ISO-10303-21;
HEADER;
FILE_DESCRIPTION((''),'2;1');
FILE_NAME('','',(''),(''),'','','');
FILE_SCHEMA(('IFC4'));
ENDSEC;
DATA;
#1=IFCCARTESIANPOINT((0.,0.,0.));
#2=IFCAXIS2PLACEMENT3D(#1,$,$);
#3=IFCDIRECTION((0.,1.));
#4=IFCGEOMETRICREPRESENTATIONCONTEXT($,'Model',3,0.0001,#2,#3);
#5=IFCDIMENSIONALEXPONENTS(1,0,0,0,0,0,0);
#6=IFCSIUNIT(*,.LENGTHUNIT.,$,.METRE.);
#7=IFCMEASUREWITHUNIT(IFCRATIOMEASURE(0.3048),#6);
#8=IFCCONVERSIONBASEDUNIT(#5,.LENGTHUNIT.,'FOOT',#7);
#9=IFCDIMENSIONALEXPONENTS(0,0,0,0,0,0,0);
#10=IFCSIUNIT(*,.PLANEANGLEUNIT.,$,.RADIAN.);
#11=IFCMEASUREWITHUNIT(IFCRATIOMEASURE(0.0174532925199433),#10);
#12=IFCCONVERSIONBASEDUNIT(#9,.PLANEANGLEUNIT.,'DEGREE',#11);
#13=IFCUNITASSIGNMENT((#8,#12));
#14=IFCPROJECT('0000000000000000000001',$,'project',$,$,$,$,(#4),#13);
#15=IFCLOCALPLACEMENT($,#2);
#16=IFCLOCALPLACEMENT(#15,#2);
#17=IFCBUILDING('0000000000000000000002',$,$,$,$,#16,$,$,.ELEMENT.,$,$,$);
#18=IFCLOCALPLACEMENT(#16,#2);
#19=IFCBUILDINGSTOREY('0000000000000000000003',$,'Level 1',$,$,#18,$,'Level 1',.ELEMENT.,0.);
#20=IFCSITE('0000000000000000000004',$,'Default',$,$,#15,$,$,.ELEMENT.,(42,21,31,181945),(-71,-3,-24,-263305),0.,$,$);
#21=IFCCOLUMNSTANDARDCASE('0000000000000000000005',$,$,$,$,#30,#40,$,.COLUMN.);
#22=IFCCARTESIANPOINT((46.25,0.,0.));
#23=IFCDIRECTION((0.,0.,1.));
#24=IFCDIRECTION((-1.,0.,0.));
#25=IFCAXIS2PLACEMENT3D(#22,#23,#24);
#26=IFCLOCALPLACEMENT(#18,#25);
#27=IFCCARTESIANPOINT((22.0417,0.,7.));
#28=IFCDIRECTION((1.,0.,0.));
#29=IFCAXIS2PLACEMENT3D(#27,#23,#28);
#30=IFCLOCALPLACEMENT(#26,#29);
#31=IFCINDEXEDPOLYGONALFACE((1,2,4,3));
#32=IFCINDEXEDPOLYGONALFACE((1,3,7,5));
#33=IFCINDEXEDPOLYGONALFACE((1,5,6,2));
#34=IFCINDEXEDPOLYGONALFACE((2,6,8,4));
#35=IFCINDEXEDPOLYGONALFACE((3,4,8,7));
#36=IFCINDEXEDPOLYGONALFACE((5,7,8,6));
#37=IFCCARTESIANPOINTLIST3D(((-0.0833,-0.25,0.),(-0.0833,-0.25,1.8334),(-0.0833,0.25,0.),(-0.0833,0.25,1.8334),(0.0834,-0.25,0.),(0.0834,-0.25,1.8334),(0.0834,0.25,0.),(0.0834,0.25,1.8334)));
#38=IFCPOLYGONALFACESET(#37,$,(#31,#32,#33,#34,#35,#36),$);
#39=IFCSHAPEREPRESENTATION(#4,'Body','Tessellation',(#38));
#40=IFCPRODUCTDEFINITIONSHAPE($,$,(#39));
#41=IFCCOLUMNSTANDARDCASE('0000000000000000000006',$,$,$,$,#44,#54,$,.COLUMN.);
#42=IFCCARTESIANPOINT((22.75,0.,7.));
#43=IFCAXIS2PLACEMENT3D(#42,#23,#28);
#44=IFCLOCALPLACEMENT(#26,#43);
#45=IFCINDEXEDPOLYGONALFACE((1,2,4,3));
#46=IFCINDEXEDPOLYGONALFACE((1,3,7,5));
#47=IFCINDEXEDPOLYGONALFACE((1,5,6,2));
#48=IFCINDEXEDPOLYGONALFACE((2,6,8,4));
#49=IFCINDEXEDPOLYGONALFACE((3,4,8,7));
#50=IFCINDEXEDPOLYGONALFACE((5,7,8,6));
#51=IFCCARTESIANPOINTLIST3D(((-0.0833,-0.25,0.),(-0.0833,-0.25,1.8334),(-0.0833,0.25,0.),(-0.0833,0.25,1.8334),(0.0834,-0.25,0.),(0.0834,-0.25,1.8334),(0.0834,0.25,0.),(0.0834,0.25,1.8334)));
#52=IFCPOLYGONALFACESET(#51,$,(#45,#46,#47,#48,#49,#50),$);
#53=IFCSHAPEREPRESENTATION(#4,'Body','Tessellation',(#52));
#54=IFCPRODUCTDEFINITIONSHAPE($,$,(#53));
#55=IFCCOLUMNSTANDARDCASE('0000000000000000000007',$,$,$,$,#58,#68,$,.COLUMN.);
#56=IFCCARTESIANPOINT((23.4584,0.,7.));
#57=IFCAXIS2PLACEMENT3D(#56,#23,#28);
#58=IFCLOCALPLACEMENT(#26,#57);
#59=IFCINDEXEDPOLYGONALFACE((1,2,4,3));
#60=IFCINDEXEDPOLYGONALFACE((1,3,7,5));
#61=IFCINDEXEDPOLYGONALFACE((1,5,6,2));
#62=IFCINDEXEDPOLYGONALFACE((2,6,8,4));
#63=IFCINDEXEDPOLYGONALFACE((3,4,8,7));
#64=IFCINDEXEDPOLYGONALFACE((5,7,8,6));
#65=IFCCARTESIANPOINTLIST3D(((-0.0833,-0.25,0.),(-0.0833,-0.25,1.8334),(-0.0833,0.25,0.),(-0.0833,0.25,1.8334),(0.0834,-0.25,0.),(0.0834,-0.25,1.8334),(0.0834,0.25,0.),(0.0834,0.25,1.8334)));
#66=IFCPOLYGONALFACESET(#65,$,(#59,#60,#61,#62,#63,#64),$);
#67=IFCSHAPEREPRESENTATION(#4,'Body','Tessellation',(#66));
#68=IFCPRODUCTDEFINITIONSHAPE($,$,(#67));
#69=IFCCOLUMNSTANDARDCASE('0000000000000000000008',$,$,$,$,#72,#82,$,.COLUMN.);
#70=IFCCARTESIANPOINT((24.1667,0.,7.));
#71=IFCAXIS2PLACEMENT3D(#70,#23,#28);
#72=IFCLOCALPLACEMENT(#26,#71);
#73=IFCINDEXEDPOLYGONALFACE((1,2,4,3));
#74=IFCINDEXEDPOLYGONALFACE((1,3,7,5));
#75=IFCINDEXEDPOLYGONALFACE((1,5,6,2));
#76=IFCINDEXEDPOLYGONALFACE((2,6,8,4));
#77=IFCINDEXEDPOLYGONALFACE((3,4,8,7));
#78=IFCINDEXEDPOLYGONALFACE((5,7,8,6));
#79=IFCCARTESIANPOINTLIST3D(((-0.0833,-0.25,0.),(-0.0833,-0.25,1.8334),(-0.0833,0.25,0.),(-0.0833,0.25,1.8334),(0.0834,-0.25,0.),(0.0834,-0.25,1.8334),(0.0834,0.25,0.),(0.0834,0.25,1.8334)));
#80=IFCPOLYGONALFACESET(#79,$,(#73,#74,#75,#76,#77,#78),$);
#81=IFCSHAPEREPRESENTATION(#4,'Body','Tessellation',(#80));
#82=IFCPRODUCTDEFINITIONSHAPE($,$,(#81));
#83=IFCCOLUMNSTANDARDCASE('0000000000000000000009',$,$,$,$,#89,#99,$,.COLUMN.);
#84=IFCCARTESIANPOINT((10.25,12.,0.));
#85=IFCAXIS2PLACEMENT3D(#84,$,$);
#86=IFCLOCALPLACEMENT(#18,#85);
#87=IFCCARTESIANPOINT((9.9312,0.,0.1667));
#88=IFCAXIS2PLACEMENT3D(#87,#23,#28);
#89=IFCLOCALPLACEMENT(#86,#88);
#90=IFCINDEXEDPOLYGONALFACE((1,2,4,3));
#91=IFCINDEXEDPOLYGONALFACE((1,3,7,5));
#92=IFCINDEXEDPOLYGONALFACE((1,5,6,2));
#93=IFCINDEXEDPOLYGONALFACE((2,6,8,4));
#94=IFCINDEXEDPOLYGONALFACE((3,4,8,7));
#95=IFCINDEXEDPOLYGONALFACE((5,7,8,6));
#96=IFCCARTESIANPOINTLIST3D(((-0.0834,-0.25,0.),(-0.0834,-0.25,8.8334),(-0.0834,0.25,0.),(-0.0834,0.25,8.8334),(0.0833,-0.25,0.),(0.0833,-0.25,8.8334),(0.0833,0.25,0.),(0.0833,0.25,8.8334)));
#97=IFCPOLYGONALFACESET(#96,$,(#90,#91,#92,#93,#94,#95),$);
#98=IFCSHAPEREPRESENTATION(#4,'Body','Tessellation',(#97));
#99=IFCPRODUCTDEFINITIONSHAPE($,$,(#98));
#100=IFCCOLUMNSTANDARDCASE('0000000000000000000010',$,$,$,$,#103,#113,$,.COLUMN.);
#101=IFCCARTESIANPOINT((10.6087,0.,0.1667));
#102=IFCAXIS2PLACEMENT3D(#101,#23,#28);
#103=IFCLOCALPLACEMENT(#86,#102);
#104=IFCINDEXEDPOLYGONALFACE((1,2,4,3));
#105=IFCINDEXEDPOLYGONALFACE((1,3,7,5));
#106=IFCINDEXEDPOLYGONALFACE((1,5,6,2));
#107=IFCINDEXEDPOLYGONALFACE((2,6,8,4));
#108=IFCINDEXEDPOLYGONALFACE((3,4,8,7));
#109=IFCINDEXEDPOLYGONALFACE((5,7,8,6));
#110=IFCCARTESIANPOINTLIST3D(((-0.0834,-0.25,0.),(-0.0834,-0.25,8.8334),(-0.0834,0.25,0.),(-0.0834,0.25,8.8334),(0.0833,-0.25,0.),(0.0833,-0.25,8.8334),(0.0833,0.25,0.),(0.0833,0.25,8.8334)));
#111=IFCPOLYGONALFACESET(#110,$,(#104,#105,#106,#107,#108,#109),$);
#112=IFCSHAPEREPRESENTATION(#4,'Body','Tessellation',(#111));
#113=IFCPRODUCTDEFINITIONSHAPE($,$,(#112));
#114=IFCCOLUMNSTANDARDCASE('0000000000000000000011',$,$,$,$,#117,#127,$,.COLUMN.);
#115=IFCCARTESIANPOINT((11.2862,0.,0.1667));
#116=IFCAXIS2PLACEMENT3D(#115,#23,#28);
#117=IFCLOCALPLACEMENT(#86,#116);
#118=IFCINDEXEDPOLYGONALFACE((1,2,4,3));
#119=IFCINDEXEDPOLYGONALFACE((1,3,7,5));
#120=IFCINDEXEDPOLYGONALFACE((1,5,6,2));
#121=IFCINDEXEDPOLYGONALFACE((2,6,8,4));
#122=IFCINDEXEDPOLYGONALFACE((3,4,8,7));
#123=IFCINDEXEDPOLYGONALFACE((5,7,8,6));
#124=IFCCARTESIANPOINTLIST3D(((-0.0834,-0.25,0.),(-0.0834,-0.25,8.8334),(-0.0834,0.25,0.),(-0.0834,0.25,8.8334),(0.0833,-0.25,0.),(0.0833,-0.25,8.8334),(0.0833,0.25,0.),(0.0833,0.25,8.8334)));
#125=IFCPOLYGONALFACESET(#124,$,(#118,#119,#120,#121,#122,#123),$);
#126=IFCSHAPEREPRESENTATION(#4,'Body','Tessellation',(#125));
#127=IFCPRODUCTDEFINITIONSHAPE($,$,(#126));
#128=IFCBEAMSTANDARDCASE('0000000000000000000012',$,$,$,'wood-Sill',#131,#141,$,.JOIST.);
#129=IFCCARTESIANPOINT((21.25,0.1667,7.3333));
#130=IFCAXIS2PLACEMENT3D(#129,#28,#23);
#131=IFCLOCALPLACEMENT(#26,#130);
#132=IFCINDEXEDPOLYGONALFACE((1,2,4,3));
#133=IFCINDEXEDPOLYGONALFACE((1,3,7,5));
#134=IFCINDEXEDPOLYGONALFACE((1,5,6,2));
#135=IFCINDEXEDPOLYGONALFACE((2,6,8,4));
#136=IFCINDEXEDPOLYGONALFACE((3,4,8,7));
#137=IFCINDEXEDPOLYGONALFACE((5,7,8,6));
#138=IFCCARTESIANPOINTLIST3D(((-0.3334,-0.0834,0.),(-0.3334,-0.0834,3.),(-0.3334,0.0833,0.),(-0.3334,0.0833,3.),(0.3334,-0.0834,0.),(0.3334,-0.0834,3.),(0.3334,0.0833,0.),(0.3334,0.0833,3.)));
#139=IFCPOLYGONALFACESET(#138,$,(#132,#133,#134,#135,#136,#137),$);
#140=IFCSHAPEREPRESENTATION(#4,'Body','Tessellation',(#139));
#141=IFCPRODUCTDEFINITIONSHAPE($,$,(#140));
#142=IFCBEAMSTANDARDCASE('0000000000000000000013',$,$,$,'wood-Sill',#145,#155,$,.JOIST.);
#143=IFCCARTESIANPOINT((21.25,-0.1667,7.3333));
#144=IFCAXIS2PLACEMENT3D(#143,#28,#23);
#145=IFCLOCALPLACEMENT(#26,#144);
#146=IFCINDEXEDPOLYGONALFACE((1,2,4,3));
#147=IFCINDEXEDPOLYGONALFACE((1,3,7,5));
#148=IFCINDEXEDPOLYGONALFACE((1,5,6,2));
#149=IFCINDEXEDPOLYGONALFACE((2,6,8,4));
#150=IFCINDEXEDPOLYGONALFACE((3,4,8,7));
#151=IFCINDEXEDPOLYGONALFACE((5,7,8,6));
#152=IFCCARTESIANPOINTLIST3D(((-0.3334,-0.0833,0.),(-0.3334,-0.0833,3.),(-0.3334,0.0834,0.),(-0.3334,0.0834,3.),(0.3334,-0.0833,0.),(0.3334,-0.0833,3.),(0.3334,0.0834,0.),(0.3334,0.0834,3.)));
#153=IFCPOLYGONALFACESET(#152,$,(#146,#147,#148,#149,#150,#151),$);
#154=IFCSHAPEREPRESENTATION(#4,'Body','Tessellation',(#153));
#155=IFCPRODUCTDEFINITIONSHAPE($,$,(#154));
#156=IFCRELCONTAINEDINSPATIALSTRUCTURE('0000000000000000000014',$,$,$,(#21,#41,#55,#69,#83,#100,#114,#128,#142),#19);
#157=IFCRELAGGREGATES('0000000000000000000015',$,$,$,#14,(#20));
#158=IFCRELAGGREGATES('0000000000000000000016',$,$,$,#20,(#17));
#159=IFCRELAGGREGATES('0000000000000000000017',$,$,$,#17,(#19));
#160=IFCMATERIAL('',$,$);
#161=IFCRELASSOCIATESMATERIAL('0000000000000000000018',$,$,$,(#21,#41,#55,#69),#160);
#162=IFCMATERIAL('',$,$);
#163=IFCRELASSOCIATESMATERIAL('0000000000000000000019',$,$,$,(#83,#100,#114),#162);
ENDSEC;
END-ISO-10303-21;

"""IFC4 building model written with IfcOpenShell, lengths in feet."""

from ifc_helpers import new_model, entity, si_unit, converted_unit, direction, frame, origin, origin_with_axes, place, context, project, spatial, rectangle, extrude, material, element, save


model = new_model("IFC4")

# Units and contexts
model_context = context("Model", 3, precision=0.0001, world=origin(), true_north=direction((0.0, 1.0)))
ifc_project = project(units=[converted_unit("LENGTHUNIT", "FOOT", entity("IfcRatioMeasure", 0.3048), si_unit("LENGTHUNIT", "METRE"), dimensions=[1, 0, 0, 0, 0, 0, 0]), converted_unit("PLANEANGLEUNIT", "DEGREE", entity("IfcRatioMeasure", 0.0174532925199433), si_unit("PLANEANGLEUNIT", "RADIAN"), dimensions=[0, 0, 0, 0, 0, 0, 0])], contexts=[model_context])

# Site, building, storey
site_placement = place(None, origin())
site = spatial("IfcSite", under=ifc_project, at=site_placement, Name="Default", CompositionType="ELEMENT", RefLatitude=(42, 21, 31, 181945), RefLongitude=(-71, -3, -24, -263305), RefElevation=0.0)
building_placement = place(site_placement, origin())
building = spatial("IfcBuilding", under=site, at=building_placement, CompositionType="ELEMENT")
storey_placement = place(building_placement, origin())
storey = spatial("IfcBuildingStorey", under=building, at=storey_placement, Name="Level 1", LongName="Level 1", CompositionType="ELEMENT", Elevation=0.0)

# Columns
placement_1 = place(storey_placement, frame((46.25, 0.0, 0.0), z_axis=(0.0, 0.0, 1.0), x_axis=(-1.0, 0.0, 0.0)))
ifc_material_1 = material(Name="")
for number, where, z_axis, x_axis in (
    (1, (22.0417, 0.0, 7.0), (0.0, 0.0, 1.0), (1.0, 0.0, 0.0)),
    (2, (22.75, 0.0, 7.0), (0.0, 0.0, 1.0), (1.0, 0.0, 0.0)),
    (3, (23.4584, 0.0, 7.0), (0.0, 0.0, 1.0), (1.0, 0.0, 0.0)),
    (4, (24.1667, 0.0, 7.0), (0.0, 0.0, 1.0), (1.0, 0.0, 0.0)),
):
    element("IfcColumnStandardCase", number, at=place(placement_1, frame(where, z_axis=z_axis, x_axis=x_axis)), inside=storey, material=ifc_material_1, PredefinedType="COLUMN", context=model_context, shape_type="SweptSolid", body=[
        extrude(rectangle(XDim=0.1667, YDim=0.5), origin(), (0.0, 0.0, 1.0), 1.8334),
    ])
ifc_material_2 = material(Name="")
placement_2 = place(storey_placement, frame((10.25, 12.0, 0.0)))
for number, where, z_axis, x_axis in (
    (5, (9.9312, 0.0, 0.1667), (0.0, 0.0, 1.0), (1.0, 0.0, 0.0)),
    (6, (10.6087, 0.0, 0.1667), (0.0, 0.0, 1.0), (1.0, 0.0, 0.0)),
    (7, (11.2862, 0.0, 0.1667), (0.0, 0.0, 1.0), (1.0, 0.0, 0.0)),
):
    element("IfcColumnStandardCase", number, at=place(placement_2, frame(where, z_axis=z_axis, x_axis=x_axis)), inside=storey, material=ifc_material_2, PredefinedType="COLUMN", context=model_context, shape_type="SweptSolid", body=[
        extrude(rectangle(XDim=0.1667, YDim=0.5), origin(), (0.0, 0.0, 1.0), 8.8334),
    ])

# Beams
for number, where, z_axis, x_axis in (
    (8, (21.25, 0.1667, 7.3333), (1.0, 0.0, 0.0), (0.0, 0.0, 1.0)),
    (9, (21.25, -0.1667, 7.3333), (1.0, 0.0, 0.0), (0.0, 0.0, 1.0)),
):
    element("IfcBeamStandardCase", number, at=place(placement_1, frame(where, z_axis=z_axis, x_axis=x_axis)), inside=storey, ObjectType="wood-Sill", PredefinedType="JOIST", context=model_context, shape_type="SweptSolid", body=[
        extrude(rectangle(XDim=0.6667, YDim=0.1667), origin_with_axes(), (0.0, 0.0, 1.0), 3.0),
    ])

save(model, "model.ifc")
